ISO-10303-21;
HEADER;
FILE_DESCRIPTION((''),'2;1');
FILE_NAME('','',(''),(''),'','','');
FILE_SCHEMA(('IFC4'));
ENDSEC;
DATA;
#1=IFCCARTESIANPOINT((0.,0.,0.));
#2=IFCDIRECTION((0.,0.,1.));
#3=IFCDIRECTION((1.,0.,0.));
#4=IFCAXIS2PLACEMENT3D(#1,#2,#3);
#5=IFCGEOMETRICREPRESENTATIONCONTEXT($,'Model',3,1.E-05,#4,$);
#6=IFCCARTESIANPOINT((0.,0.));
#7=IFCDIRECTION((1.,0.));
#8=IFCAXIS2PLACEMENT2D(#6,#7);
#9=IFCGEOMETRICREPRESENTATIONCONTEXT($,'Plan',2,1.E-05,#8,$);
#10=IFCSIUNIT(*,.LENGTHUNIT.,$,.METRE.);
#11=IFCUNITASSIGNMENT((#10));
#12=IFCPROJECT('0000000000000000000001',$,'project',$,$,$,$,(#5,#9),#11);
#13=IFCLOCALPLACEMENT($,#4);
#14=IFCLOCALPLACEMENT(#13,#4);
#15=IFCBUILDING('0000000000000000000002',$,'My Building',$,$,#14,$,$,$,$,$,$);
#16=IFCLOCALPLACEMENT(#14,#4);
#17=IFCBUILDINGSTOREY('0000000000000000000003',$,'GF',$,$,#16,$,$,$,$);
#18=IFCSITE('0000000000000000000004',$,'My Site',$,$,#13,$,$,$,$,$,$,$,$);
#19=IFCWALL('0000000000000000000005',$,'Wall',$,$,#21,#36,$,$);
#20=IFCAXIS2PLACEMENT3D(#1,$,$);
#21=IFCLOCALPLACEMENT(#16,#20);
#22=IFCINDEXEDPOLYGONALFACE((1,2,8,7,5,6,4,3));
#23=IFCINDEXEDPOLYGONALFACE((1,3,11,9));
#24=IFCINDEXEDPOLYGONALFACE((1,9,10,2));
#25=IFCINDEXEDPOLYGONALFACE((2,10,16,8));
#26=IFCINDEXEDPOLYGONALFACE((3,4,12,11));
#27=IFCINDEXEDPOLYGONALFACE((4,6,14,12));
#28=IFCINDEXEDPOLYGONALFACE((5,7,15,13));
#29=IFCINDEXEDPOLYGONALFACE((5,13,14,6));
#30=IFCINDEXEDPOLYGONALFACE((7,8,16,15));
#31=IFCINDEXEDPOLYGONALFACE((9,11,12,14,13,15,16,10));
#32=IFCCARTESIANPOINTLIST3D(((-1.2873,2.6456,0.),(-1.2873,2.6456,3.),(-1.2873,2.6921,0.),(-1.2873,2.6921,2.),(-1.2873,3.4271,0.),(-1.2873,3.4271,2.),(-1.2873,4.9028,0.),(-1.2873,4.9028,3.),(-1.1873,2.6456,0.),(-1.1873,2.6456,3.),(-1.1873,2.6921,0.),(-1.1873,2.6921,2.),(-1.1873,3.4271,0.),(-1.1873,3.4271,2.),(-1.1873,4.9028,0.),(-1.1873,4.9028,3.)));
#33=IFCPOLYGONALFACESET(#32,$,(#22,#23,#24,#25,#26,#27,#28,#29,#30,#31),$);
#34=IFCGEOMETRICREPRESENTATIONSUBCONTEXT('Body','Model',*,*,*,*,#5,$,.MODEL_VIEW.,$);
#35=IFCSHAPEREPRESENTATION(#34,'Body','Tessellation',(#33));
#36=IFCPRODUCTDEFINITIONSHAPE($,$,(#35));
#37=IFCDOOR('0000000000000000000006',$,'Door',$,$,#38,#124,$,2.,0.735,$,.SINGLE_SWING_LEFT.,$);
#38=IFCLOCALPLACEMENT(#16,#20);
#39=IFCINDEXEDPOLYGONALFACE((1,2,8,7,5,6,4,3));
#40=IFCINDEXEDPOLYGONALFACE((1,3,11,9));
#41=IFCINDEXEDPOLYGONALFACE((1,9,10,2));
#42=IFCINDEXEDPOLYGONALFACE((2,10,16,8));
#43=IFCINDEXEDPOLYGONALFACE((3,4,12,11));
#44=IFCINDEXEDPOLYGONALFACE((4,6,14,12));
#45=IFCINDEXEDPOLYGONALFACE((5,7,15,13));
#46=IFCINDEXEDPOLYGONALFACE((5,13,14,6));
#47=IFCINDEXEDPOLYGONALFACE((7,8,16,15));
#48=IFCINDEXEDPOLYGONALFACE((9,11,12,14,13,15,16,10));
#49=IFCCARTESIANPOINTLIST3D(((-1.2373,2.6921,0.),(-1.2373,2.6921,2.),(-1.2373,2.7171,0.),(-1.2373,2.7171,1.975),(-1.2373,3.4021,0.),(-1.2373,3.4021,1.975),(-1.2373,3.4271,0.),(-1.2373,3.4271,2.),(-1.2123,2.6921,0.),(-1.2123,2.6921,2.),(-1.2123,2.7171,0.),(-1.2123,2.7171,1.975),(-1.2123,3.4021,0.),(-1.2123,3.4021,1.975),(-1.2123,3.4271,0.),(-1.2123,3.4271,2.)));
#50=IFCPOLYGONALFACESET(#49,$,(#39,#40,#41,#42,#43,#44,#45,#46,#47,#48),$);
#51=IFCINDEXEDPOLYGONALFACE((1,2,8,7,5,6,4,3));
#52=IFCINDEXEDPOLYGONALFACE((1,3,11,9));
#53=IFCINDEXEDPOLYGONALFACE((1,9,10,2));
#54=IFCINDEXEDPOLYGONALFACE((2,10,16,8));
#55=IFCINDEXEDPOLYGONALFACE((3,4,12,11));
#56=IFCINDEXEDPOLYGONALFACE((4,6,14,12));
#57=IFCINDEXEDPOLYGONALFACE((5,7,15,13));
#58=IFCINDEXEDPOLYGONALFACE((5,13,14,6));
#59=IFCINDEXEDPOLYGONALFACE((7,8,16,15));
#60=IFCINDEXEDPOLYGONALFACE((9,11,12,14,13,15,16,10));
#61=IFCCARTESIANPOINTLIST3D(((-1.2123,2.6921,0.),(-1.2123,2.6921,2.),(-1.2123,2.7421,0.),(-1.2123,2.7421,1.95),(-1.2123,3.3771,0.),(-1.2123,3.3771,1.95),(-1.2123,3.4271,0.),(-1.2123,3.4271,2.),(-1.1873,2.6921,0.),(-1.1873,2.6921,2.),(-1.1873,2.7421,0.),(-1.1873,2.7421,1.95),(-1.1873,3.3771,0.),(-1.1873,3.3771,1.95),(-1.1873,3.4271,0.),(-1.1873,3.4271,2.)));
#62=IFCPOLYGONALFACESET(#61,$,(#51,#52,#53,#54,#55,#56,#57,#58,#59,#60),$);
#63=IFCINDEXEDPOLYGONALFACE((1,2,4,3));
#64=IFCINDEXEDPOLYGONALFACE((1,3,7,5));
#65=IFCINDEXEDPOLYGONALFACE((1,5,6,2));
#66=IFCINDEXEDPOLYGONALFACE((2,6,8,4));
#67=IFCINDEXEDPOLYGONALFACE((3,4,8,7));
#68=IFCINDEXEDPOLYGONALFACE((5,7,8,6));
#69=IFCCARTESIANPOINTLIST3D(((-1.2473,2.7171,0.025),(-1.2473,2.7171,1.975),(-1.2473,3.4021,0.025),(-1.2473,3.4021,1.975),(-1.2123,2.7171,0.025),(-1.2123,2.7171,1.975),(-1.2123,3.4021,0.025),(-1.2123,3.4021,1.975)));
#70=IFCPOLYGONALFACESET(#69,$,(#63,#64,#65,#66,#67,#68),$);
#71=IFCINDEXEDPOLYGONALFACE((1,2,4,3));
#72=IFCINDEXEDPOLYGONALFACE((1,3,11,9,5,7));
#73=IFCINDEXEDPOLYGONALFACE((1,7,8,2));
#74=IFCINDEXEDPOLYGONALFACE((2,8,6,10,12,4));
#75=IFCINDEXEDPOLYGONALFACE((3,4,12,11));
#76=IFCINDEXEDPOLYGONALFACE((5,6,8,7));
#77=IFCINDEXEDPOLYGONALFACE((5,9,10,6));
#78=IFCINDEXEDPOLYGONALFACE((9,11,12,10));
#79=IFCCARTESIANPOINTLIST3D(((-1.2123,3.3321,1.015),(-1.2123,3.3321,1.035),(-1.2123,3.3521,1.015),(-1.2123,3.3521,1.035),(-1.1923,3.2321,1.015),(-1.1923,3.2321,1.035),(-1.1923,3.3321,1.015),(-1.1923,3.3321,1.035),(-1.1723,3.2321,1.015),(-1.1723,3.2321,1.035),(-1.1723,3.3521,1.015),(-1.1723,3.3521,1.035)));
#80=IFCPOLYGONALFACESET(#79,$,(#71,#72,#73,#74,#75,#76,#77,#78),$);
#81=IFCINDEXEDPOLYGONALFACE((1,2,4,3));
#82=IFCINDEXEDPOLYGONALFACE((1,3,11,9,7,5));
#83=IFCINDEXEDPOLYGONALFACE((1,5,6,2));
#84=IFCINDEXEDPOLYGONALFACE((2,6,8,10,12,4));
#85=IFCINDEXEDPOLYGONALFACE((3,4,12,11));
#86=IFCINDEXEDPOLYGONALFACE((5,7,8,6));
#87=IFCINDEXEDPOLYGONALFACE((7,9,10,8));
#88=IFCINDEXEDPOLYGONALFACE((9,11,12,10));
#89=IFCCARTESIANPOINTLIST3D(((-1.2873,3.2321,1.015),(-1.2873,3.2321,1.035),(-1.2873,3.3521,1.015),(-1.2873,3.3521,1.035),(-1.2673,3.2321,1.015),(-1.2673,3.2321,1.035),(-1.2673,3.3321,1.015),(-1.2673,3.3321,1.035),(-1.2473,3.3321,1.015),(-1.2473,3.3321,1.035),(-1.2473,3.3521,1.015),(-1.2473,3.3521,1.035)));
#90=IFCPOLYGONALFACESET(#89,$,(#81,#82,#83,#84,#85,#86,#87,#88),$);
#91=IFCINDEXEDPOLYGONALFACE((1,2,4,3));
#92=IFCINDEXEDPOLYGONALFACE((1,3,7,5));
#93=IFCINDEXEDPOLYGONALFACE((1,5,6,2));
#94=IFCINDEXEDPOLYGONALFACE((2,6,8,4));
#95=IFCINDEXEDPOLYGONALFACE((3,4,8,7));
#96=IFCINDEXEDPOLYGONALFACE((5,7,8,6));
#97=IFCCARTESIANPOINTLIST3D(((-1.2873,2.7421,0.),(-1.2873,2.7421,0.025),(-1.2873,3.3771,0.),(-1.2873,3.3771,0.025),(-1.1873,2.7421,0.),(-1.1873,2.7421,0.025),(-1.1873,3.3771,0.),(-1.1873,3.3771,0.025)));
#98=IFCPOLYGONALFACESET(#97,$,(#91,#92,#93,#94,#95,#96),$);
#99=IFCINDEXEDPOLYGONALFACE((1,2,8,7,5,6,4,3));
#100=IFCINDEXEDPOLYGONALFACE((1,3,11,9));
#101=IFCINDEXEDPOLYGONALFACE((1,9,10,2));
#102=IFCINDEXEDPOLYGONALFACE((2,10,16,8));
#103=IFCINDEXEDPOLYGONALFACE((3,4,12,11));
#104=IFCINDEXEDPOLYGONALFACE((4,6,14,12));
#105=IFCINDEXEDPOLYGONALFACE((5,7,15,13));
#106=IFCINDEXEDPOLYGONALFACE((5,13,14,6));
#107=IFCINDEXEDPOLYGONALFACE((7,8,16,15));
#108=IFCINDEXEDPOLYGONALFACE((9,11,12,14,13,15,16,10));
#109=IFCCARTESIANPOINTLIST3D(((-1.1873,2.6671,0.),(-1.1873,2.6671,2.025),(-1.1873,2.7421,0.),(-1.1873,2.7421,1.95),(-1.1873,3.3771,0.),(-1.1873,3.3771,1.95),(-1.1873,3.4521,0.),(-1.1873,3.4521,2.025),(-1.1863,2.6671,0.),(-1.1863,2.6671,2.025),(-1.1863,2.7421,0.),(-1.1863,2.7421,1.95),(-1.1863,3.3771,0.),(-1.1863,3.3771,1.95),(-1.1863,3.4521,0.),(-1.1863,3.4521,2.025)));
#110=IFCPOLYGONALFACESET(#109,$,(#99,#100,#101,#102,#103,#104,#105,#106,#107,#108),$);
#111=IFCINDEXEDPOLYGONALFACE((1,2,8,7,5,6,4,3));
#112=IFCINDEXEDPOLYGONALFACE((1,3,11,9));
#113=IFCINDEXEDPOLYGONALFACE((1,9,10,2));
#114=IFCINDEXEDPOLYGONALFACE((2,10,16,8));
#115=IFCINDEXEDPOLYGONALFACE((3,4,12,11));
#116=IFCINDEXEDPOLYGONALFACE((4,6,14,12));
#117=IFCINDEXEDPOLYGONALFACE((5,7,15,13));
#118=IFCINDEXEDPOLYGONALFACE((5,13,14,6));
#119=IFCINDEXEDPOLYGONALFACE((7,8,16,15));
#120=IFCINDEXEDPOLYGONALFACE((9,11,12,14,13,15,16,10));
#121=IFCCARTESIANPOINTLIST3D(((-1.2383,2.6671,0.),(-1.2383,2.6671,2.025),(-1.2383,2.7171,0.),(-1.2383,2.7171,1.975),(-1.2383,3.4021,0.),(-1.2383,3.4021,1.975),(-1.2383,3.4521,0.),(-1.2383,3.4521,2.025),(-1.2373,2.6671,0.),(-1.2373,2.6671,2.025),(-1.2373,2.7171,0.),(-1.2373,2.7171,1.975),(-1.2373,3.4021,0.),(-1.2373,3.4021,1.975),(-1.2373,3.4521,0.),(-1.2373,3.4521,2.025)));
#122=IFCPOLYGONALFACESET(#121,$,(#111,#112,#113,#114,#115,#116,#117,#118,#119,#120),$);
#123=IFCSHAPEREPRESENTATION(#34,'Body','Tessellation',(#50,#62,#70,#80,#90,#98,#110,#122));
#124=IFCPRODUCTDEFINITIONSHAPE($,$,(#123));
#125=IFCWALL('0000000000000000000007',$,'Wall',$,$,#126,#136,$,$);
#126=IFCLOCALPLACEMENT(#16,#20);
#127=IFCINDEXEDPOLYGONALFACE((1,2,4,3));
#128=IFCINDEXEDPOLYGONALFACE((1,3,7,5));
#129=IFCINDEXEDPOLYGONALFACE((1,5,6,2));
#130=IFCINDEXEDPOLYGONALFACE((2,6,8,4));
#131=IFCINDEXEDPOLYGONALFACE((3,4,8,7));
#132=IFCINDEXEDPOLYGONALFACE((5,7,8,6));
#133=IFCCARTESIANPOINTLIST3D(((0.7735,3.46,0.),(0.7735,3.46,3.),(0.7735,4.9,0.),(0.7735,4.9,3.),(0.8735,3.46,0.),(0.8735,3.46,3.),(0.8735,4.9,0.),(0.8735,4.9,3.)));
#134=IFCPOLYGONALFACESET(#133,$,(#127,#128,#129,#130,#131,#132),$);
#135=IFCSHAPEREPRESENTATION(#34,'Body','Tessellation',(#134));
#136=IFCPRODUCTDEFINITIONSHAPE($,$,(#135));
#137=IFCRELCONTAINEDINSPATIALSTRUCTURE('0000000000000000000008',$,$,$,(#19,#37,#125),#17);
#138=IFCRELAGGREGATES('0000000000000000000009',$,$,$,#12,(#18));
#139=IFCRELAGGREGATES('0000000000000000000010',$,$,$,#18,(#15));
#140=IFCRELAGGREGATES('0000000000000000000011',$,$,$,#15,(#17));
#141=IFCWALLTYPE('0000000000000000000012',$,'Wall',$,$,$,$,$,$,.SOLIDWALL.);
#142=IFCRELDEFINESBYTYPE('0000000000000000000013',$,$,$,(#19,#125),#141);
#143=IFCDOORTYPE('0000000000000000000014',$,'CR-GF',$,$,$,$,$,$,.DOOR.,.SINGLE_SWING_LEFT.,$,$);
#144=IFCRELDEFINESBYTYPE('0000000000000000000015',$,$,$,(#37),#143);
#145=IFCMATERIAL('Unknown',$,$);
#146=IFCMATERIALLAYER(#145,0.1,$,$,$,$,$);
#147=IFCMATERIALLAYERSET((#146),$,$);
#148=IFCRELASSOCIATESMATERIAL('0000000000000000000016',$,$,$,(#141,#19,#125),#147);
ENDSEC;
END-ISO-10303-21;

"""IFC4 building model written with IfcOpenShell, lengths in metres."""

from ifc_helpers import new_model, entity, si_unit, frame, origin_with_axes, origin_2d_with_axis, place, context, subcontext, project, spatial, line, indexed_curve, outline, extrude, shape, source, transform, mapped, material, layer, layer_set, layer_usage, type_object, type_shapes, element, fill, save


model = new_model("IFC4")

# Units and contexts
model_context = context("Model", 3, precision=1e-05, world=origin_with_axes())
plan_context = context("Plan", 2, precision=1e-05, world=origin_2d_with_axis())
body_context_1 = subcontext(model_context, "Body", "Model", "MODEL_VIEW")
body_context_2 = subcontext(plan_context, "Body", "Plan", "PLAN_VIEW")
ifc_project = project(units=[si_unit("LENGTHUNIT", "METRE")], contexts=[model_context, plan_context])

# Site, building, storey
site_placement = place(None, origin_with_axes())
site = spatial("IfcSite", under=ifc_project, at=site_placement, Name="My Site")
building_placement = place(site_placement, origin_with_axes())
building = spatial("IfcBuilding", under=site, at=building_placement, Name="My Building")
storey_placement = place(building_placement, origin_with_axes())
storey = spatial("IfcBuildingStorey", under=building, at=storey_placement, Name="GF")

# Shared definitions
ifc_material_1 = material(Name="Unknown")

# Shared definitions
ifc_layer_1 = layer(ifc_material_1, 0.1)
ifc_layer_set_1 = layer_set([ifc_layer_1])
wall_type = type_object("IfcWallType", Name="Wall", PredefinedType="SOLIDWALL", material=ifc_layer_set_1)

# Wall, opening, door
ifc_layer_usage_1 = layer_usage(ifc_layer_set_1, "AXIS2", "POSITIVE", 0.0)
wall_1_placement = place(storey_placement, frame((-1.1873, 2.5456, 0.0), z_axis=(0.0, 0.0, 1.0), x_axis=(0.0, 1.0, 0.0)))
wall_1 = element("IfcWall", 1, at=wall_1_placement, inside=storey, type_object=wall_type, material=ifc_layer_usage_1, Name="Wall", context=body_context_1, shape_type="SweptSolid", body=[
    extrude(outline(indexed_curve([(0.1, 0.0), (0.1, 0.1), (2.3572, 0.1), (2.3572, 0.0)], segments=[line(1, 2, 3, 4, 1)])), origin_with_axes(), (0.0, 0.0, 1.0), 3.0),
])
shared_shape_1 = source(origin_with_axes(), body_context_1, "Body", "SweptSolid", [
    extrude(outline(indexed_curve([(0.0, 0.0), (0.735, 0.0), (0.735, 2.0), (0.0, 2.0)], segments=[line(1, 2, 3, 4, 1)])), frame((0.0, -0.6, 0.0), z_axis=(0.0, -1.0, 0.0), x_axis=(1.0, 0.0, 0.0)), (0.0, 0.0, -1.0), 1.2),
])
opening_1_placement = place(wall_1_placement, frame((0.1466, 0.0, 0.0), z_axis=(0.0, 0.0, 1.0), x_axis=(1.0, 0.0, 0.0)))
opening_1 = element("IfcOpeningElement", 2, at=opening_1_placement, cuts=wall_1, PredefinedType="OPENING", context=body_context_1, shape_type="MappedRepresentation", body=[
    mapped(shared_shape_1, transform((0.0, 0.0, 0.0), x_axis=(1.0, 0.0, 0.0), y_axis=(0.0, 1.0, 0.0), z_axis=(0.0, 0.0, 1.0), scale=1.0)),
])
door_type_1 = type_object("IfcDoorType", Name="CR-GF", OperationType="SINGLE_SWING_LEFT", PredefinedType="DOOR")
shared_shape_2 = source(origin_with_axes(), body_context_1, "Body", "SweptSolid", [
    extrude(outline(indexed_curve([(0.0, 0.0), (0.0, 2.0), (0.735, 2.0), (0.735, 0.0), (0.71, 0.0), (0.71, 1.975), (0.025, 1.975), (0.025, 0.0)], segments=[line(1, 2, 3, 4, 5, 6, 7, 8, 1)])), frame((0.0, 0.025, 0.0), z_axis=(0.0, -1.0, 0.0), x_axis=(1.0, 0.0, 0.0)), (0.0, 0.0, -1.0), 0.025),
    extrude(outline(indexed_curve([(0.0, 0.0), (0.0, 2.0), (0.735, 2.0), (0.735, 0.0), (0.685, 0.0), (0.685, 1.95), (0.05, 1.95), (0.05, 0.0)], segments=[line(1, 2, 3, 4, 5, 6, 7, 8, 1)])), frame((0.0, 0.0, 0.0), z_axis=(0.0, -1.0, 0.0), x_axis=(1.0, 0.0, 0.0)), (0.0, 0.0, -1.0), 0.025),
    extrude(outline(indexed_curve([(0.0, 0.0), (0.685, 0.0), (0.685, 0.035), (0.0, 0.035)], segments=[line(1, 2, 3, 4, 1)])), frame((0.025, 0.025, 0.025), z_axis=(0.0, 0.0, 1.0), x_axis=(1.0, 0.0, 0.0)), (0.0, 0.0, 1.0), 1.95),
    extrude(outline(indexed_curve([(0.0, 0.0), (0.0, -0.04), (-0.12, -0.04), (-0.12, -0.02), (-0.02, -0.02), (-0.02, 0.0)], segments=[line(1, 2, 3, 4, 5, 6, 1)])), frame((0.66, 0.025, 1.015), z_axis=(0.0, 0.0, 1.0), x_axis=(1.0, 0.0, 0.0)), (0.0, 0.0, 1.0), 0.02),
    extrude(outline(indexed_curve([(0.0, 0.0), (0.0, 0.04), (-0.12, 0.04), (-0.12, 0.02), (-0.02, 0.02), (-0.02, 0.0)], segments=[line(1, 2, 3, 4, 5, 6, 1)])), frame((0.66, 0.06, 1.015), z_axis=(0.0, 0.0, 1.0), x_axis=(1.0, 0.0, 0.0)), (0.0, 0.0, 1.0), 0.02),
    extrude(outline(indexed_curve([(0.0, 0.0), (0.635, 0.0), (0.635, 0.1), (0.0, 0.1)], segments=[line(1, 2, 3, 4, 1)])), frame((0.05, 0.0, 0.0), z_axis=(0.0, 0.0, 1.0), x_axis=(1.0, 0.0, 0.0)), (0.0, 0.0, 1.0), 0.025),
    extrude(outline(indexed_curve([(0.0, 0.0), (0.0, 2.025), (0.785, 2.025), (0.785, 0.0), (0.71, 0.0), (0.71, 1.95), (0.075, 1.95), (0.075, 0.0)], segments=[line(1, 2, 3, 4, 5, 6, 7, 8, 1)])), frame((-0.025, -0.001, 0.0), z_axis=(0.0, -1.0, 0.0), x_axis=(1.0, 0.0, 0.0)), (0.0, 0.0, -1.0), 0.001),
    extrude(outline(indexed_curve([(0.0, 0.0), (0.0, 2.025), (0.785, 2.025), (0.785, 0.0), (0.735, 0.0), (0.735, 1.975), (0.05, 1.975), (0.05, 0.0)], segments=[line(1, 2, 3, 4, 5, 6, 7, 8, 1)])), frame((-0.025, 0.05, 0.0), z_axis=(0.0, -1.0, 0.0), x_axis=(1.0, 0.0, 0.0)), (0.0, 0.0, -1.0), 0.001),
])
shared_shape_3 = source(origin_with_axes(), body_context_2, "Body", "Curve2D", [
    entity("IfcIndexedPolyCurve", entity("IfcCartesianPointList2D", [[0.0, 0.0], [0.0, 0.05], [0.025, 0.05], [0.025, 0.025], [0.05, 0.025], [0.05, 0.0]]), [entity("IfcLineIndex", [1, 2, 3, 4, 5, 6, 1])]),
    entity("IfcIndexedPolyCurve", entity("IfcCartesianPointList2D", [[0.735, 0.0], [0.735, 0.05], [0.71, 0.05], [0.71, 0.025], [0.685, 0.025], [0.685, 0.0]]), [entity("IfcLineIndex", [1, 2, 3, 4, 5, 6, 1])]),
    entity("IfcTrimmedCurve", entity("IfcEllipse", entity("IfcAxis2Placement2D", entity("IfcCartesianPoint", [0.06, 0.05]), entity("IfcDirection", [1.0, 0.0])), 0.65, 0.685), [entity("IfcCartesianPoint", [0.71, 0.05])], [entity("IfcCartesianPoint", [0.06, 0.735])], True, "CARTESIAN"),
    entity("IfcIndexedPolyCurve", entity("IfcCartesianPointList2D", [[0.025, 0.05], [0.06, 0.05], [0.06, 0.735], [0.025, 0.735]]), [entity("IfcLineIndex", [1, 2, 3, 4, 1])]),
])
type_shapes(door_type_1, [shared_shape_2, shared_shape_3])
door_1_placement = place(opening_1_placement, frame((0.0, 0.0, 0.0), z_axis=(0.0, 0.0, 1.0), x_axis=(1.0, 0.0, 0.0)))
door_1 = element("IfcDoor", 3, at=door_1_placement, inside=storey, type_object=door_type_1, Name="Door", OperationType="SINGLE_SWING_LEFT", OverallHeight=2.0, OverallWidth=0.735, shapes=[
    shape(body_context_1, "Body", "MappedRepresentation", [mapped(shared_shape_2, transform((0.0, 0.0, 0.0), x_axis=(1.0, 0.0, 0.0), y_axis=(0.0, 1.0, 0.0), z_axis=(0.0, 0.0, 1.0), scale=1.0))]),
    shape(body_context_2, "Body", "MappedRepresentation", [mapped(shared_shape_3, transform((0.0, 0.0, 0.0), x_axis=(1.0, 0.0, 0.0), y_axis=(0.0, 1.0, 0.0), z_axis=(0.0, 0.0, 1.0), scale=1.0))]),
])
fill(opening_1, door_1)

# Wall
ifc_layer_usage_2 = layer_usage(ifc_layer_set_1, "AXIS2", "POSITIVE", 0.0)
wall_2_placement = place(storey_placement, frame((0.7735, 4.9, 0.0), z_axis=(0.0, 0.0, 1.0), x_axis=(0.0, -1.0, 0.0)))
element("IfcWall", 4, at=wall_2_placement, inside=storey, type_object=wall_type, material=ifc_layer_usage_2, Name="Wall", context=body_context_1, shape_type="SweptSolid", body=[
    extrude(outline(indexed_curve([(0.0, 0.0), (0.0, 0.1), (1.44, 0.1), (1.44, 0.0)], segments=[line(1, 2, 3, 4, 1)])), origin_with_axes(), (0.0, 0.0, 1.0), 3.0),
])

save(model, "model.ifc")
